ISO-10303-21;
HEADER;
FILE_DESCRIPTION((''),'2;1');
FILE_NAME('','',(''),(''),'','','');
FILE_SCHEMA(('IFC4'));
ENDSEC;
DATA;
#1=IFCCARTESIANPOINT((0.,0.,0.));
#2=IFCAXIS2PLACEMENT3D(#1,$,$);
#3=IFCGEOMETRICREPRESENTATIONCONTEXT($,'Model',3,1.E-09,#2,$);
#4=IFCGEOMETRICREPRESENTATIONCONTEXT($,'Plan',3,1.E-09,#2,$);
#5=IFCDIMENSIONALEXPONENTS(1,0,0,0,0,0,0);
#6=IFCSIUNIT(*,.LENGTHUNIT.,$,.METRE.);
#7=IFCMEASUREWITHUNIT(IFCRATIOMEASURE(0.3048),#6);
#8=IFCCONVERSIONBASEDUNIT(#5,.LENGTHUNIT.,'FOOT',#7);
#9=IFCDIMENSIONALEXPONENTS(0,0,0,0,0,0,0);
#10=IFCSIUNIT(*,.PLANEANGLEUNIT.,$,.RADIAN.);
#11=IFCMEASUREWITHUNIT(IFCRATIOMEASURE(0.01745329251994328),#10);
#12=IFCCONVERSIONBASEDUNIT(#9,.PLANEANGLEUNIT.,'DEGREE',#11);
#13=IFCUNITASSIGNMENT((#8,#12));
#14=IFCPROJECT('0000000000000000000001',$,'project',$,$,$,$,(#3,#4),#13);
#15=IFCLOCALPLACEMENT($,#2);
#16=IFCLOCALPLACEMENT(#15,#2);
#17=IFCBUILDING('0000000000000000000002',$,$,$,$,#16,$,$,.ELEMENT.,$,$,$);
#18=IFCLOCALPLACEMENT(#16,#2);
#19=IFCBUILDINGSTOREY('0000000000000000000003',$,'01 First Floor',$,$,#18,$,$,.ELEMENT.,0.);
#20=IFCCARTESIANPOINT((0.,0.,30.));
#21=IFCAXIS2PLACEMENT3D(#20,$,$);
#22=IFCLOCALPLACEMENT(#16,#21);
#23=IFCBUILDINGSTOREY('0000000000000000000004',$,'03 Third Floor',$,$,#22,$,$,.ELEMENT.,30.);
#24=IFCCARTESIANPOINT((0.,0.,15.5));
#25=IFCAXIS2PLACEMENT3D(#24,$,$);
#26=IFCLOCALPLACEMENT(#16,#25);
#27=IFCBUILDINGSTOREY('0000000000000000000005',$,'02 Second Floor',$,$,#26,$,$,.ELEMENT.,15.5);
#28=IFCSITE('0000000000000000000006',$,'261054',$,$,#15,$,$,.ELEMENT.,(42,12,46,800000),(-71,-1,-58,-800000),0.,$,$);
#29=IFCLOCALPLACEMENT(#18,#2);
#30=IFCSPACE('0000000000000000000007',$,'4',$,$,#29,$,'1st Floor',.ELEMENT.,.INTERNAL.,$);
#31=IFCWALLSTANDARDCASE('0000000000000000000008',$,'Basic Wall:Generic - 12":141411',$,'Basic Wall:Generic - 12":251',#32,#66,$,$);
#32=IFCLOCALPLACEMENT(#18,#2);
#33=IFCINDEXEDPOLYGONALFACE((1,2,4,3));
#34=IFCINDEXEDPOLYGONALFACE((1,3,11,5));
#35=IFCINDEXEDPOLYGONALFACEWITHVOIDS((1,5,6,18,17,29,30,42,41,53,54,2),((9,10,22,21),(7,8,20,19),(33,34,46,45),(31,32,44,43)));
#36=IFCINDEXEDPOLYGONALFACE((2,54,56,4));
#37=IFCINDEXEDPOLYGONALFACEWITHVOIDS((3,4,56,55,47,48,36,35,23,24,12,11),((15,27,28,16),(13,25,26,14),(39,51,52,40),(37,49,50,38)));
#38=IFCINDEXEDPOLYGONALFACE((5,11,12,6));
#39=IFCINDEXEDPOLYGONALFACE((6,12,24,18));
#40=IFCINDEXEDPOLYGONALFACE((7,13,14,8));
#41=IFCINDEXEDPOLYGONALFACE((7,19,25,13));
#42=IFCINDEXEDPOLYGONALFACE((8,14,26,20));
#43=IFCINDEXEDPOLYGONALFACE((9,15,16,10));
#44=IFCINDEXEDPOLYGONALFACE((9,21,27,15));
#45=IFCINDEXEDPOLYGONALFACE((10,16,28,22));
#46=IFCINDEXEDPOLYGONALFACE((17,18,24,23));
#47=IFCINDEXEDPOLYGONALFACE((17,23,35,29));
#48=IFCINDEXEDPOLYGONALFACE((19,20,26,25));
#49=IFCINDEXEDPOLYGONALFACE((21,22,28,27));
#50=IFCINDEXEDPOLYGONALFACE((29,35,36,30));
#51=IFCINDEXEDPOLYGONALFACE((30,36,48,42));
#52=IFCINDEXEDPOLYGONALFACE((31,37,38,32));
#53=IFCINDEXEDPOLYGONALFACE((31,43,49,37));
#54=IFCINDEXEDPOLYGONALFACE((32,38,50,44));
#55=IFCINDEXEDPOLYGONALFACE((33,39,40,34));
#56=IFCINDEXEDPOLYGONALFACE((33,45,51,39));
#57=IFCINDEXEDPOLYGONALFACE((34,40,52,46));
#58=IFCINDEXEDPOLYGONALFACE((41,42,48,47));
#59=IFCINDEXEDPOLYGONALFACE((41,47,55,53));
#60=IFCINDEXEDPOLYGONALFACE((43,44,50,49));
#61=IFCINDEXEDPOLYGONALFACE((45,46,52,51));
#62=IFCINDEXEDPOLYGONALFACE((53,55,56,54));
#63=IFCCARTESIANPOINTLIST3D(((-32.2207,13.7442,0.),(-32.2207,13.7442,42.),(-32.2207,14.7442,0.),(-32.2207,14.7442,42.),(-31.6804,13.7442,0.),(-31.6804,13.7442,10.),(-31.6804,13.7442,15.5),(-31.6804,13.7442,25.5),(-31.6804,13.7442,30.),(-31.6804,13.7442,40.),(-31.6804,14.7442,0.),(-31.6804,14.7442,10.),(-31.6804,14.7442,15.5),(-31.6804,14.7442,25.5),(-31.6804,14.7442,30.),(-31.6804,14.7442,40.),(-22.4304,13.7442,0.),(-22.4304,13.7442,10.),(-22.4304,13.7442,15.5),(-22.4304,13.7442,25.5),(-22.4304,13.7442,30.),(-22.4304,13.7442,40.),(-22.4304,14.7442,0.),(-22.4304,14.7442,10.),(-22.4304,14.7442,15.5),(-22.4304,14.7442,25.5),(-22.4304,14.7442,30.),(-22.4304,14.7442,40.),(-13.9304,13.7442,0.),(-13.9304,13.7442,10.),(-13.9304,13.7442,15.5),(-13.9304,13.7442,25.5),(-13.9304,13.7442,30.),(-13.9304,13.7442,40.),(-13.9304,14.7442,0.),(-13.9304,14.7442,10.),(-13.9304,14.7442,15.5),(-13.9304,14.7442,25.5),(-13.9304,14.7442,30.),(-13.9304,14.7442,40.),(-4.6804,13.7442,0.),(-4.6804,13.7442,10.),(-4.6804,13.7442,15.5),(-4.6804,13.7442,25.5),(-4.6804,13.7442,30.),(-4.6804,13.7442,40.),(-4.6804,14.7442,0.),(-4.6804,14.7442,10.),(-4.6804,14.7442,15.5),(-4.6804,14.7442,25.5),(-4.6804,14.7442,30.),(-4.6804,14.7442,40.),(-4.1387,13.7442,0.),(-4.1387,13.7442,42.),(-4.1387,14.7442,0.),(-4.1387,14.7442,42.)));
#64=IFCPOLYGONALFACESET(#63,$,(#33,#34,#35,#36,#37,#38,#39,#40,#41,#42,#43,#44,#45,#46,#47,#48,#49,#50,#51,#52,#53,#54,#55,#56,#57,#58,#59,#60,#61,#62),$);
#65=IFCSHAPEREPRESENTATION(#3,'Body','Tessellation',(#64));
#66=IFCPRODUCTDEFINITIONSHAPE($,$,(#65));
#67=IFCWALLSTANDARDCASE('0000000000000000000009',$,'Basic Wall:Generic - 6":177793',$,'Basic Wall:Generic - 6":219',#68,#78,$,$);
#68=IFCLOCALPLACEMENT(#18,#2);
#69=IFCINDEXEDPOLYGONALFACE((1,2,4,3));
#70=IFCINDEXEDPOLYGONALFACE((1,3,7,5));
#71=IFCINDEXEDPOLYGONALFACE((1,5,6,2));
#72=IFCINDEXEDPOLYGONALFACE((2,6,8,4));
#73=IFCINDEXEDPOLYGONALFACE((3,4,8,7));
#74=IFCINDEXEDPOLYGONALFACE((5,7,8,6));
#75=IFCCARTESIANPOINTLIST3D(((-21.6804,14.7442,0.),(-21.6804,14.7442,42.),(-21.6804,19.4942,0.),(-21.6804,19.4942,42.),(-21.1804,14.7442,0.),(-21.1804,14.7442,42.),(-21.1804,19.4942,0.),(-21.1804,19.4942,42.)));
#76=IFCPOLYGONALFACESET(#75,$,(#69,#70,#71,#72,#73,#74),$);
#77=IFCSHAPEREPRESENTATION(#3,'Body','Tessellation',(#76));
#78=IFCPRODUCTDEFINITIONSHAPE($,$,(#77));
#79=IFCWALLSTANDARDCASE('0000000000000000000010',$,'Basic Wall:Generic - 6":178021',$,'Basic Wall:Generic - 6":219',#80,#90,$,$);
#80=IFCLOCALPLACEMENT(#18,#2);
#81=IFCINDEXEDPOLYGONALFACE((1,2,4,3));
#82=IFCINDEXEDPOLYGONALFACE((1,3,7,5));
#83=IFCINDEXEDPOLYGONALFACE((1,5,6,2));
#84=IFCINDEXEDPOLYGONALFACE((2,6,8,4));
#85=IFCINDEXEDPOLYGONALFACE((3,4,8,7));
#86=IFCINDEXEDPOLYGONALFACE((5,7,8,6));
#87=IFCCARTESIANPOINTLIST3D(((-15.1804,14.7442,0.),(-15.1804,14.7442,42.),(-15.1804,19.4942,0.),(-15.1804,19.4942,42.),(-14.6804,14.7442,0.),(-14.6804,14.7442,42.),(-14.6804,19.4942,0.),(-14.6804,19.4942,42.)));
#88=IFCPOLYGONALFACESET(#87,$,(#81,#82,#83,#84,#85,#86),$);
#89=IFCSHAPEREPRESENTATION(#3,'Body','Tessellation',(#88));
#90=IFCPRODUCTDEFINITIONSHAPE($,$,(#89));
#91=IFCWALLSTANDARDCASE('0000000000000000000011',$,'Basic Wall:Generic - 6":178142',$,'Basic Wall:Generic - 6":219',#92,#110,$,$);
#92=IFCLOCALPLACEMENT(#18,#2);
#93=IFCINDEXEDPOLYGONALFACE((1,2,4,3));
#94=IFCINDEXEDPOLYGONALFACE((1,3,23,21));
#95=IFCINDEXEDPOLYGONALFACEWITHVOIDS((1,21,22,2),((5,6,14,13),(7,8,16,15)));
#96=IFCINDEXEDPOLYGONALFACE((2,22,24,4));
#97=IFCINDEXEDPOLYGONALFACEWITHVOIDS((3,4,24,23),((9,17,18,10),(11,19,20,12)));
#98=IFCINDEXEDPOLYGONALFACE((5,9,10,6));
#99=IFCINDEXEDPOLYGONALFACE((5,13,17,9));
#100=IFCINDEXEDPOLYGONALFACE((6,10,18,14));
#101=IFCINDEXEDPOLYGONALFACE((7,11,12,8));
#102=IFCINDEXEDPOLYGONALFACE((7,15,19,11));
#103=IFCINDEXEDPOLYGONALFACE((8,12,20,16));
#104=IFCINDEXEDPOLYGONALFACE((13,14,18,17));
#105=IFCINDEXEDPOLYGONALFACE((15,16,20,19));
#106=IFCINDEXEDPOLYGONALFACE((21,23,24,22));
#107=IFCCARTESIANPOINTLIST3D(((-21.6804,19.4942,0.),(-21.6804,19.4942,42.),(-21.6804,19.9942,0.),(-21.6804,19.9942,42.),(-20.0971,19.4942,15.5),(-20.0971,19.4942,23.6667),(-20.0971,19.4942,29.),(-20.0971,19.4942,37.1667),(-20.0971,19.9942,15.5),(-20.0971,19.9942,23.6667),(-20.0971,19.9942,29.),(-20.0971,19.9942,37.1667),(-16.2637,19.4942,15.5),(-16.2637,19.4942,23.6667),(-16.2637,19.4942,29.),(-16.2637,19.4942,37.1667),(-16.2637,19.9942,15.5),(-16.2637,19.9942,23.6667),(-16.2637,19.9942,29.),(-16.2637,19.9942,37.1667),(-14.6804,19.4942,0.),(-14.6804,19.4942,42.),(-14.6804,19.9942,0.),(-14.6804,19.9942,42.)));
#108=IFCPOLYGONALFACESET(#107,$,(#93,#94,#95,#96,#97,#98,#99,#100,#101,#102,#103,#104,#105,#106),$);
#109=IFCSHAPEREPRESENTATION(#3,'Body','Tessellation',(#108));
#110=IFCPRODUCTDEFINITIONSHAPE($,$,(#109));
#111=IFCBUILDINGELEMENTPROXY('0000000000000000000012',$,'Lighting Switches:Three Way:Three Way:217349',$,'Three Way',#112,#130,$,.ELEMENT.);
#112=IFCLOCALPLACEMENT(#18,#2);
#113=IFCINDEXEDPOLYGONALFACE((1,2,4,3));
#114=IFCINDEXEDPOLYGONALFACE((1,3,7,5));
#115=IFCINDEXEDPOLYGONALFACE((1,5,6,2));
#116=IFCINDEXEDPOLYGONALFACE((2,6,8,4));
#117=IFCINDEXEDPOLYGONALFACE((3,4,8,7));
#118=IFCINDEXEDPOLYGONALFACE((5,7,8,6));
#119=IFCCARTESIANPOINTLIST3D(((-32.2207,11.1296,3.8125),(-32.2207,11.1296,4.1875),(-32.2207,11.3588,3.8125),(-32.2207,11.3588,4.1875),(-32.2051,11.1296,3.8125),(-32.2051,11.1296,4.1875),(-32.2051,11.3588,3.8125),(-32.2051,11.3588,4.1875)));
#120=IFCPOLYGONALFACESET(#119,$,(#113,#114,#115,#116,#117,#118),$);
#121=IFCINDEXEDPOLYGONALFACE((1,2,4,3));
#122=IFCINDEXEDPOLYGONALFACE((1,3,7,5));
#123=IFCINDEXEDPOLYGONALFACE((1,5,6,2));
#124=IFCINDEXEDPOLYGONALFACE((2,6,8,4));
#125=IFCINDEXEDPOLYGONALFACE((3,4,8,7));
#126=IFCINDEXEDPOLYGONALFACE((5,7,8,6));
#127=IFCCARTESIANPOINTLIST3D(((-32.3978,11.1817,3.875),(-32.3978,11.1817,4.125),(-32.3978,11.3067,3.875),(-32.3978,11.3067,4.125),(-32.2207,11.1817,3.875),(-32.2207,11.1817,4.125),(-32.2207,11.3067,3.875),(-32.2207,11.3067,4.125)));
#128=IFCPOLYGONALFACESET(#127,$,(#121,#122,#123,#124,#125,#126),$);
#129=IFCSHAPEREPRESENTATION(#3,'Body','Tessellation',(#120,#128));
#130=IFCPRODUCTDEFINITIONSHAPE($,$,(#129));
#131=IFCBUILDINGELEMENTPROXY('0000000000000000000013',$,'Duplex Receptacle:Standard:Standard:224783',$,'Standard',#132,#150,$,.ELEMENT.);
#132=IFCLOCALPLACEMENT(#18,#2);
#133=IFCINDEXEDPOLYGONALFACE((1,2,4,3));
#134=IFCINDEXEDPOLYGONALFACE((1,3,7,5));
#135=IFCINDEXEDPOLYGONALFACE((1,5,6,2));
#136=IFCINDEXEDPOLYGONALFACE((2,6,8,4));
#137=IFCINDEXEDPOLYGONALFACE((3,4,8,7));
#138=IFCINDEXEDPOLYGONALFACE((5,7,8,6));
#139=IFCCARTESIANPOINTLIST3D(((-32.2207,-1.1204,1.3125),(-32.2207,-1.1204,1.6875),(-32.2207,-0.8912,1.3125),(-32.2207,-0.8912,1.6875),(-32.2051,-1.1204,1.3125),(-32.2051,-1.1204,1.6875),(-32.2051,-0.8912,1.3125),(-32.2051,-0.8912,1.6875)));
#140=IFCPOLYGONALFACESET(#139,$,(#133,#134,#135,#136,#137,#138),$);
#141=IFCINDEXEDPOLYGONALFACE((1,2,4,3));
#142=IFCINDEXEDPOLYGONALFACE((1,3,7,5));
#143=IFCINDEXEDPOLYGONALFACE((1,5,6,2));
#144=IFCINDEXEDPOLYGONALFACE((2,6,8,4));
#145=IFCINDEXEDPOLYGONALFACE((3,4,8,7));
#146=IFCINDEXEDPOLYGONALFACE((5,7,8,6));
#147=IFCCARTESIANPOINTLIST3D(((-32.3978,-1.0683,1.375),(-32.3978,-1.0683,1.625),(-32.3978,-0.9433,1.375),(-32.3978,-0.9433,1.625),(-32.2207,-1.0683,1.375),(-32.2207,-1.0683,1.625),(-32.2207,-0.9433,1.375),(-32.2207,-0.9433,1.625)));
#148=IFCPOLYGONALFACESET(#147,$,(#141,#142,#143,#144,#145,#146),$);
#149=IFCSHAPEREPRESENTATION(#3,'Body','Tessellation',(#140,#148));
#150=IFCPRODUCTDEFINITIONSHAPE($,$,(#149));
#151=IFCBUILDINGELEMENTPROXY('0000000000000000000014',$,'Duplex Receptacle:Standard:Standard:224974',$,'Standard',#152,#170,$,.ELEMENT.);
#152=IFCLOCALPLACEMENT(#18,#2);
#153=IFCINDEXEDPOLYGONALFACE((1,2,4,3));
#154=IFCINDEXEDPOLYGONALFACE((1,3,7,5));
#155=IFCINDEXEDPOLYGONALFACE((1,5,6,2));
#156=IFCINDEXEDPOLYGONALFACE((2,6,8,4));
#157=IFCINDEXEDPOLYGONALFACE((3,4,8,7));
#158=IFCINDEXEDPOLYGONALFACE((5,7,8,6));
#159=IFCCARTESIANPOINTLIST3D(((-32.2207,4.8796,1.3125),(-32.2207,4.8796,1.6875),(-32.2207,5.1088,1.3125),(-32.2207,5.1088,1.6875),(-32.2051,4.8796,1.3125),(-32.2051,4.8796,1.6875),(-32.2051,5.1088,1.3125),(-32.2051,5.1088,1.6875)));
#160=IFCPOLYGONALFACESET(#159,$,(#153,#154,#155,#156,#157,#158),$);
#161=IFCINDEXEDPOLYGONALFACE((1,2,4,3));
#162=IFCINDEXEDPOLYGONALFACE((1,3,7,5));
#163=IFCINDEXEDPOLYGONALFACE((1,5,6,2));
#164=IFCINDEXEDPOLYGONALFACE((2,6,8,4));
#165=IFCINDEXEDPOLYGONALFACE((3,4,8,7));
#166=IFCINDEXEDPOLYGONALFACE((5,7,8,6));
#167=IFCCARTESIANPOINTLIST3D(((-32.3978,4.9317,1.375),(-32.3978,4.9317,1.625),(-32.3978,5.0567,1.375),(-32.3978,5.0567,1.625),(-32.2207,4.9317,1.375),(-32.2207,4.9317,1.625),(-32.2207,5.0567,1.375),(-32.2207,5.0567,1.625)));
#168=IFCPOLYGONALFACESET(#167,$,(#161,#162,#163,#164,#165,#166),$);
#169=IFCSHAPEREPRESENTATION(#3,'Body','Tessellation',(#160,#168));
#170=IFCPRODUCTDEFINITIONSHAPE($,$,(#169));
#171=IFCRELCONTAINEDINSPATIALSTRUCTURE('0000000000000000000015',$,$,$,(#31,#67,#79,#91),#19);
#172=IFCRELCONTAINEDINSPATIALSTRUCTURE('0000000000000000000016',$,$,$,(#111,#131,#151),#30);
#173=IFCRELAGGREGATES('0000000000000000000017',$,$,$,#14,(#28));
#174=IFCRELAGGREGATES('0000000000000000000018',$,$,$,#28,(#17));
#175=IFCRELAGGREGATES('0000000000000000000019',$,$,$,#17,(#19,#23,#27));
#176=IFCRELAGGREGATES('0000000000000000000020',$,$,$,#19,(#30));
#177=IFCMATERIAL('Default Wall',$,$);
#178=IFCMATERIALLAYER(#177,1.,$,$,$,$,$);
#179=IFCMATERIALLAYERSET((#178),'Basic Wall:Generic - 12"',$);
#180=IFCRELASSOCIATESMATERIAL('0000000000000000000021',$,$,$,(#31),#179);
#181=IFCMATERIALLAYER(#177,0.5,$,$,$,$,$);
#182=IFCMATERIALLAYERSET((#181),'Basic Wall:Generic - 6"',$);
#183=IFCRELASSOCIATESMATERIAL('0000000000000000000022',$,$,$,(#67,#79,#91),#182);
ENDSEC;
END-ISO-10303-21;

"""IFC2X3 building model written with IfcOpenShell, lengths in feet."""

from ifc_helpers import new_model, entity, si_unit, converted_unit, frame, frame_2d, origin, origin_2d_with_axis, place, context, project, spatial, rectangle, extrude, source, transform, mapped, material, layer, layer_set, layer_usage, element, save


model = new_model("IFC2X3")

# Units and contexts
model_context = context("Model", 3, precision=1e-09, world=origin())
plan_context = context("Plan", 3, precision=1e-09, world=origin())
ifc_project = project(units=[converted_unit("LENGTHUNIT", "FOOT", entity("IfcRatioMeasure", 0.3048), si_unit("LENGTHUNIT", "METRE"), dimensions=[1, 0, 0, 0, 0, 0, 0]), converted_unit("PLANEANGLEUNIT", "DEGREE", entity("IfcRatioMeasure", 0.01745329251994328), si_unit("PLANEANGLEUNIT", "RADIAN"), dimensions=[0, 0, 0, 0, 0, 0, 0])], contexts=[model_context, plan_context])

# Site, building, storey
site_placement = place(None, origin())
site = spatial("IfcSite", under=ifc_project, at=site_placement, Name="261054", CompositionType="ELEMENT", RefLatitude=(42, 12, 46, 800000), RefLongitude=(-71, -1, -58, -800000), RefElevation=0.0)
building_placement = place(site_placement, origin())
building = spatial("IfcBuilding", under=site, at=building_placement, CompositionType="ELEMENT")
storey_1_placement = place(building_placement, origin())
storey_1 = spatial("IfcBuildingStorey", under=building, at=storey_1_placement, Name="01 First Floor", CompositionType="ELEMENT", Elevation=0.0)

# Wall, openings
ifc_material_1 = material(Name="Default Wall")
ifc_layer_1 = layer(ifc_material_1, 1.0)
ifc_layer_set_1 = layer_set([ifc_layer_1], Name="Basic Wall:Generic - 12\"")
ifc_layer_usage_1 = layer_usage(ifc_layer_set_1, "AXIS2", "NEGATIVE", 0.5)
wall_1_placement = place(storey_1_placement, frame((-32.2207, 14.2442, 0.0)))
wall_1 = element("IfcWallStandardCase", 1, at=wall_1_placement, inside=storey_1, material=ifc_layer_usage_1, Name="Basic Wall:Generic - 12\":141411", ObjectType="Basic Wall:Generic - 12\":251", context=model_context, shape_type="SweptSolid", body=[
    extrude(rectangle(XDim=28.082, YDim=1.0, at=frame_2d((14.041, 0.0), x_axis=(-1.0, 0.0))), origin(), (0.0, 0.0, 1.0), 42.0),
])
opening_1_placement = place(wall_1_placement, origin())
element("IfcOpeningElement", 2, at=opening_1_placement, cuts=wall_1, ObjectType="Opening", context=model_context, shape_type="SweptSolid", body=[
    extrude(rectangle(XDim=10.0, YDim=9.25, at=origin_2d_with_axis()), frame((22.9153, -0.5, 5.0), z_axis=(0.0, 1.0, 0.0), x_axis=(0.0, 0.0, -1.0)), (0.0, 0.0, 1.0), 1.0),
])
opening_2_placement = place(wall_1_placement, origin())
element("IfcOpeningElement", 3, at=opening_2_placement, cuts=wall_1, ObjectType="Opening", context=model_context, shape_type="SweptSolid", body=[
    extrude(rectangle(XDim=10.0, YDim=9.25, at=origin_2d_with_axis()), frame((5.1653, -0.5, 5.0), z_axis=(0.0, 1.0, 0.0), x_axis=(0.0, 0.0, -1.0)), (0.0, 0.0, 1.0), 1.0),
])
opening_3_placement = place(wall_1_placement, origin())
element("IfcOpeningElement", 4, at=opening_3_placement, cuts=wall_1, ObjectType="Opening", context=model_context, shape_type="SweptSolid", body=[
    extrude(rectangle(XDim=10.0, YDim=9.25, at=origin_2d_with_axis()), frame((22.9153, -0.5, 20.5), z_axis=(0.0, 1.0, 0.0), x_axis=(0.0, 0.0, -1.0)), (0.0, 0.0, 1.0), 1.0),
])
opening_4_placement = place(wall_1_placement, origin())
element("IfcOpeningElement", 5, at=opening_4_placement, cuts=wall_1, ObjectType="Opening", context=model_context, shape_type="SweptSolid", body=[
    extrude(rectangle(XDim=10.0, YDim=9.25, at=origin_2d_with_axis()), frame((22.9153, -0.5, 35.0), z_axis=(0.0, 1.0, 0.0), x_axis=(0.0, 0.0, -1.0)), (0.0, 0.0, 1.0), 1.0),
])
opening_5_placement = place(wall_1_placement, origin())
element("IfcOpeningElement", 6, at=opening_5_placement, cuts=wall_1, ObjectType="Opening", context=model_context, shape_type="SweptSolid", body=[
    extrude(rectangle(XDim=10.0, YDim=9.25, at=origin_2d_with_axis()), frame((5.1653, -0.5, 20.5), z_axis=(0.0, 1.0, 0.0), x_axis=(0.0, 0.0, -1.0)), (0.0, 0.0, 1.0), 1.0),
])
opening_6_placement = place(wall_1_placement, origin())
element("IfcOpeningElement", 7, at=opening_6_placement, cuts=wall_1, ObjectType="Opening", context=model_context, shape_type="SweptSolid", body=[
    extrude(rectangle(XDim=10.0, YDim=9.25, at=origin_2d_with_axis()), frame((5.1653, -0.5, 35.0), z_axis=(0.0, 1.0, 0.0), x_axis=(0.0, 0.0, -1.0)), (0.0, 0.0, 1.0), 1.0),
])

# Shared definitions
storey_2_placement = place(building_placement, frame((0.0, 0.0, 30.0)))
storey_2 = spatial("IfcBuildingStorey", under=building, at=storey_2_placement, Name="03 Third Floor", CompositionType="ELEMENT", Elevation=30.0)

# Shared definitions
storey_3_placement = place(building_placement, frame((0.0, 0.0, 15.5)))
storey_3 = spatial("IfcBuildingStorey", under=building, at=storey_3_placement, Name="02 Second Floor", CompositionType="ELEMENT", Elevation=15.5)

# Walls
ifc_layer_2 = layer(ifc_material_1, 0.5)
ifc_layer_set_2 = layer_set([ifc_layer_2], Name="Basic Wall:Generic - 6\"")
ifc_layer_usage_2 = layer_usage(ifc_layer_set_2, "AXIS2", "NEGATIVE", 0.25)
wall_2_placement = place(storey_1_placement, frame((-21.4304, 14.7442, 0.0), z_axis=(0.0, 0.0, 1.0), x_axis=(0.0, 1.0, 0.0)))
element("IfcWallStandardCase", 8, at=wall_2_placement, inside=storey_1, material=ifc_layer_usage_2, Name="Basic Wall:Generic - 6\":177793", ObjectType="Basic Wall:Generic - 6\":219", context=model_context, shape_type="SweptSolid", body=[
    extrude(rectangle(XDim=4.75, YDim=0.5, at=frame_2d((2.375, 0.0), x_axis=(-1.0, 0.0))), origin(), (0.0, 0.0, 1.0), 42.0),
])
ifc_layer_usage_3 = layer_usage(ifc_layer_set_2, "AXIS2", "POSITIVE", -0.25)
wall_3_placement = place(storey_1_placement, frame((-14.9304, 14.7442, 0.0), z_axis=(0.0, 0.0, 1.0), x_axis=(0.0, 1.0, 0.0)))
element("IfcWallStandardCase", 9, at=wall_3_placement, inside=storey_1, material=ifc_layer_usage_3, Name="Basic Wall:Generic - 6\":178021", ObjectType="Basic Wall:Generic - 6\":219", context=model_context, shape_type="SweptSolid", body=[
    extrude(rectangle(XDim=4.75, YDim=0.5, at=frame_2d((2.375, 0.0), x_axis=(-1.0, 0.0))), origin(), (0.0, 0.0, 1.0), 42.0),
])

# Wall, openings
ifc_layer_usage_4 = layer_usage(ifc_layer_set_2, "AXIS2", "NEGATIVE", 0.25)
wall_4_placement = place(storey_1_placement, frame((-21.6804, 19.7442, 0.0)))
wall_4 = element("IfcWallStandardCase", 10, at=wall_4_placement, inside=storey_1, material=ifc_layer_usage_4, Name="Basic Wall:Generic - 6\":178142", ObjectType="Basic Wall:Generic - 6\":219", context=model_context, shape_type="SweptSolid", body=[
    extrude(rectangle(XDim=7.0, YDim=0.5, at=frame_2d((3.5, 0.0), x_axis=(-1.0, 0.0))), origin(), (0.0, 0.0, 1.0), 42.0),
])
opening_7_placement = place(wall_4_placement, frame((5.4167, 0.25, 15.5)))
element("IfcOpeningElement", 11, at=opening_7_placement, cuts=wall_4, ObjectType="Opening", context=model_context, shape_type="SweptSolid", body=[
    extrude(rectangle(XDim=8.1667, YDim=3.8333, at=frame_2d((4.0833, 1.9167), x_axis=(1.0, 0.0))), frame((0.0, 0.0, 0.0), z_axis=(0.0, -1.0, 0.0), x_axis=(0.0, 0.0, 1.0)), (0.0, 0.0, 1.0), 0.5),
])
opening_8_placement = place(wall_4_placement, frame((5.4167, 0.25, 29.0)))
element("IfcOpeningElement", 12, at=opening_8_placement, cuts=wall_4, ObjectType="Opening", context=model_context, shape_type="SweptSolid", body=[
    extrude(rectangle(XDim=8.1667, YDim=3.8333, at=frame_2d((4.0833, 1.9167), x_axis=(1.0, 0.0))), frame((0.0, 0.0, 0.0), z_axis=(0.0, -1.0, 0.0), x_axis=(0.0, 0.0, 1.0)), (0.0, 0.0, 1.0), 0.5),
])

# Shared definitions
space_placement = place(storey_1_placement, origin())
space = spatial("IfcSpace", under=storey_1, at=space_placement, Name="4", LongName="1st Floor", CompositionType="ELEMENT", InteriorOrExteriorSpace="INTERNAL")

# Building element proxies
shared_shape_1 = source(origin(), model_context, "Body", "SweptSolid", [
    extrude(rectangle(XDim=0.2292, YDim=0.375, at=origin_2d_with_axis()), frame((0.0, 0.0, 0.0), z_axis=(0.0, 0.0, 1.0), x_axis=(-1.0, 0.0, 0.0)), (0.0, 0.0, 1.0), 0.0156),
    extrude(rectangle(XDim=0.125, YDim=0.25, at=origin_2d_with_axis()), frame((0.0, 0.0, -0.1771), z_axis=(0.0, 0.0, 1.0), x_axis=(-1.0, 0.0, 0.0)), (0.0, 0.0, 1.0), 0.1771),
])
proxy_placement = place(space_placement, frame((-32.2207, 11.2442, 4.0), z_axis=(1.0, 0.0, 0.0), x_axis=(0.0, 1.0, 0.0)))
element("IfcBuildingElementProxy", 13, at=proxy_placement, inside=space, Name="Lighting Switches:Three Way:Three Way:217349", ObjectType="Three Way", CompositionType="ELEMENT", context=model_context, shape_type="MappedRepresentation", body=[
    mapped(shared_shape_1, transform((0.0, 0.0, 0.0), scale=1.0)),
])
shared_shape_2 = source(origin(), model_context, "Body", "SweptSolid", [
    extrude(rectangle(XDim=0.2292, YDim=0.375, at=origin_2d_with_axis()), frame((0.0, 0.0, 0.0), z_axis=(0.0, 0.0, 1.0), x_axis=(-1.0, 0.0, 0.0)), (0.0, 0.0, 1.0), 0.0156),
    extrude(rectangle(XDim=0.125, YDim=0.25, at=origin_2d_with_axis()), frame((0.0, 0.0, -0.1771), z_axis=(0.0, 0.0, 1.0), x_axis=(-1.0, 0.0, 0.0)), (0.0, 0.0, 1.0), 0.1771),
])
for number, where, z_axis, x_axis, name in (
    (14, (-32.2207, -1.0058, 1.5), (1.0, 0.0, 0.0), (0.0, 1.0, 0.0), "Duplex Receptacle:Standard:Standard:224783"),
    (15, (-32.2207, 4.9942, 1.5), (1.0, 0.0, 0.0), (0.0, 1.0, 0.0), "Duplex Receptacle:Standard:Standard:224974"),
):
    element("IfcBuildingElementProxy", number, at=place(space_placement, frame(where, z_axis=z_axis, x_axis=x_axis)), inside=space, Name=name, ObjectType="Standard", CompositionType="ELEMENT", context=model_context, shape_type="MappedRepresentation", body=[
        mapped(shared_shape_2, transform((0.0, 0.0, 0.0), scale=1.0)),
    ])

save(model, "model.ifc")
